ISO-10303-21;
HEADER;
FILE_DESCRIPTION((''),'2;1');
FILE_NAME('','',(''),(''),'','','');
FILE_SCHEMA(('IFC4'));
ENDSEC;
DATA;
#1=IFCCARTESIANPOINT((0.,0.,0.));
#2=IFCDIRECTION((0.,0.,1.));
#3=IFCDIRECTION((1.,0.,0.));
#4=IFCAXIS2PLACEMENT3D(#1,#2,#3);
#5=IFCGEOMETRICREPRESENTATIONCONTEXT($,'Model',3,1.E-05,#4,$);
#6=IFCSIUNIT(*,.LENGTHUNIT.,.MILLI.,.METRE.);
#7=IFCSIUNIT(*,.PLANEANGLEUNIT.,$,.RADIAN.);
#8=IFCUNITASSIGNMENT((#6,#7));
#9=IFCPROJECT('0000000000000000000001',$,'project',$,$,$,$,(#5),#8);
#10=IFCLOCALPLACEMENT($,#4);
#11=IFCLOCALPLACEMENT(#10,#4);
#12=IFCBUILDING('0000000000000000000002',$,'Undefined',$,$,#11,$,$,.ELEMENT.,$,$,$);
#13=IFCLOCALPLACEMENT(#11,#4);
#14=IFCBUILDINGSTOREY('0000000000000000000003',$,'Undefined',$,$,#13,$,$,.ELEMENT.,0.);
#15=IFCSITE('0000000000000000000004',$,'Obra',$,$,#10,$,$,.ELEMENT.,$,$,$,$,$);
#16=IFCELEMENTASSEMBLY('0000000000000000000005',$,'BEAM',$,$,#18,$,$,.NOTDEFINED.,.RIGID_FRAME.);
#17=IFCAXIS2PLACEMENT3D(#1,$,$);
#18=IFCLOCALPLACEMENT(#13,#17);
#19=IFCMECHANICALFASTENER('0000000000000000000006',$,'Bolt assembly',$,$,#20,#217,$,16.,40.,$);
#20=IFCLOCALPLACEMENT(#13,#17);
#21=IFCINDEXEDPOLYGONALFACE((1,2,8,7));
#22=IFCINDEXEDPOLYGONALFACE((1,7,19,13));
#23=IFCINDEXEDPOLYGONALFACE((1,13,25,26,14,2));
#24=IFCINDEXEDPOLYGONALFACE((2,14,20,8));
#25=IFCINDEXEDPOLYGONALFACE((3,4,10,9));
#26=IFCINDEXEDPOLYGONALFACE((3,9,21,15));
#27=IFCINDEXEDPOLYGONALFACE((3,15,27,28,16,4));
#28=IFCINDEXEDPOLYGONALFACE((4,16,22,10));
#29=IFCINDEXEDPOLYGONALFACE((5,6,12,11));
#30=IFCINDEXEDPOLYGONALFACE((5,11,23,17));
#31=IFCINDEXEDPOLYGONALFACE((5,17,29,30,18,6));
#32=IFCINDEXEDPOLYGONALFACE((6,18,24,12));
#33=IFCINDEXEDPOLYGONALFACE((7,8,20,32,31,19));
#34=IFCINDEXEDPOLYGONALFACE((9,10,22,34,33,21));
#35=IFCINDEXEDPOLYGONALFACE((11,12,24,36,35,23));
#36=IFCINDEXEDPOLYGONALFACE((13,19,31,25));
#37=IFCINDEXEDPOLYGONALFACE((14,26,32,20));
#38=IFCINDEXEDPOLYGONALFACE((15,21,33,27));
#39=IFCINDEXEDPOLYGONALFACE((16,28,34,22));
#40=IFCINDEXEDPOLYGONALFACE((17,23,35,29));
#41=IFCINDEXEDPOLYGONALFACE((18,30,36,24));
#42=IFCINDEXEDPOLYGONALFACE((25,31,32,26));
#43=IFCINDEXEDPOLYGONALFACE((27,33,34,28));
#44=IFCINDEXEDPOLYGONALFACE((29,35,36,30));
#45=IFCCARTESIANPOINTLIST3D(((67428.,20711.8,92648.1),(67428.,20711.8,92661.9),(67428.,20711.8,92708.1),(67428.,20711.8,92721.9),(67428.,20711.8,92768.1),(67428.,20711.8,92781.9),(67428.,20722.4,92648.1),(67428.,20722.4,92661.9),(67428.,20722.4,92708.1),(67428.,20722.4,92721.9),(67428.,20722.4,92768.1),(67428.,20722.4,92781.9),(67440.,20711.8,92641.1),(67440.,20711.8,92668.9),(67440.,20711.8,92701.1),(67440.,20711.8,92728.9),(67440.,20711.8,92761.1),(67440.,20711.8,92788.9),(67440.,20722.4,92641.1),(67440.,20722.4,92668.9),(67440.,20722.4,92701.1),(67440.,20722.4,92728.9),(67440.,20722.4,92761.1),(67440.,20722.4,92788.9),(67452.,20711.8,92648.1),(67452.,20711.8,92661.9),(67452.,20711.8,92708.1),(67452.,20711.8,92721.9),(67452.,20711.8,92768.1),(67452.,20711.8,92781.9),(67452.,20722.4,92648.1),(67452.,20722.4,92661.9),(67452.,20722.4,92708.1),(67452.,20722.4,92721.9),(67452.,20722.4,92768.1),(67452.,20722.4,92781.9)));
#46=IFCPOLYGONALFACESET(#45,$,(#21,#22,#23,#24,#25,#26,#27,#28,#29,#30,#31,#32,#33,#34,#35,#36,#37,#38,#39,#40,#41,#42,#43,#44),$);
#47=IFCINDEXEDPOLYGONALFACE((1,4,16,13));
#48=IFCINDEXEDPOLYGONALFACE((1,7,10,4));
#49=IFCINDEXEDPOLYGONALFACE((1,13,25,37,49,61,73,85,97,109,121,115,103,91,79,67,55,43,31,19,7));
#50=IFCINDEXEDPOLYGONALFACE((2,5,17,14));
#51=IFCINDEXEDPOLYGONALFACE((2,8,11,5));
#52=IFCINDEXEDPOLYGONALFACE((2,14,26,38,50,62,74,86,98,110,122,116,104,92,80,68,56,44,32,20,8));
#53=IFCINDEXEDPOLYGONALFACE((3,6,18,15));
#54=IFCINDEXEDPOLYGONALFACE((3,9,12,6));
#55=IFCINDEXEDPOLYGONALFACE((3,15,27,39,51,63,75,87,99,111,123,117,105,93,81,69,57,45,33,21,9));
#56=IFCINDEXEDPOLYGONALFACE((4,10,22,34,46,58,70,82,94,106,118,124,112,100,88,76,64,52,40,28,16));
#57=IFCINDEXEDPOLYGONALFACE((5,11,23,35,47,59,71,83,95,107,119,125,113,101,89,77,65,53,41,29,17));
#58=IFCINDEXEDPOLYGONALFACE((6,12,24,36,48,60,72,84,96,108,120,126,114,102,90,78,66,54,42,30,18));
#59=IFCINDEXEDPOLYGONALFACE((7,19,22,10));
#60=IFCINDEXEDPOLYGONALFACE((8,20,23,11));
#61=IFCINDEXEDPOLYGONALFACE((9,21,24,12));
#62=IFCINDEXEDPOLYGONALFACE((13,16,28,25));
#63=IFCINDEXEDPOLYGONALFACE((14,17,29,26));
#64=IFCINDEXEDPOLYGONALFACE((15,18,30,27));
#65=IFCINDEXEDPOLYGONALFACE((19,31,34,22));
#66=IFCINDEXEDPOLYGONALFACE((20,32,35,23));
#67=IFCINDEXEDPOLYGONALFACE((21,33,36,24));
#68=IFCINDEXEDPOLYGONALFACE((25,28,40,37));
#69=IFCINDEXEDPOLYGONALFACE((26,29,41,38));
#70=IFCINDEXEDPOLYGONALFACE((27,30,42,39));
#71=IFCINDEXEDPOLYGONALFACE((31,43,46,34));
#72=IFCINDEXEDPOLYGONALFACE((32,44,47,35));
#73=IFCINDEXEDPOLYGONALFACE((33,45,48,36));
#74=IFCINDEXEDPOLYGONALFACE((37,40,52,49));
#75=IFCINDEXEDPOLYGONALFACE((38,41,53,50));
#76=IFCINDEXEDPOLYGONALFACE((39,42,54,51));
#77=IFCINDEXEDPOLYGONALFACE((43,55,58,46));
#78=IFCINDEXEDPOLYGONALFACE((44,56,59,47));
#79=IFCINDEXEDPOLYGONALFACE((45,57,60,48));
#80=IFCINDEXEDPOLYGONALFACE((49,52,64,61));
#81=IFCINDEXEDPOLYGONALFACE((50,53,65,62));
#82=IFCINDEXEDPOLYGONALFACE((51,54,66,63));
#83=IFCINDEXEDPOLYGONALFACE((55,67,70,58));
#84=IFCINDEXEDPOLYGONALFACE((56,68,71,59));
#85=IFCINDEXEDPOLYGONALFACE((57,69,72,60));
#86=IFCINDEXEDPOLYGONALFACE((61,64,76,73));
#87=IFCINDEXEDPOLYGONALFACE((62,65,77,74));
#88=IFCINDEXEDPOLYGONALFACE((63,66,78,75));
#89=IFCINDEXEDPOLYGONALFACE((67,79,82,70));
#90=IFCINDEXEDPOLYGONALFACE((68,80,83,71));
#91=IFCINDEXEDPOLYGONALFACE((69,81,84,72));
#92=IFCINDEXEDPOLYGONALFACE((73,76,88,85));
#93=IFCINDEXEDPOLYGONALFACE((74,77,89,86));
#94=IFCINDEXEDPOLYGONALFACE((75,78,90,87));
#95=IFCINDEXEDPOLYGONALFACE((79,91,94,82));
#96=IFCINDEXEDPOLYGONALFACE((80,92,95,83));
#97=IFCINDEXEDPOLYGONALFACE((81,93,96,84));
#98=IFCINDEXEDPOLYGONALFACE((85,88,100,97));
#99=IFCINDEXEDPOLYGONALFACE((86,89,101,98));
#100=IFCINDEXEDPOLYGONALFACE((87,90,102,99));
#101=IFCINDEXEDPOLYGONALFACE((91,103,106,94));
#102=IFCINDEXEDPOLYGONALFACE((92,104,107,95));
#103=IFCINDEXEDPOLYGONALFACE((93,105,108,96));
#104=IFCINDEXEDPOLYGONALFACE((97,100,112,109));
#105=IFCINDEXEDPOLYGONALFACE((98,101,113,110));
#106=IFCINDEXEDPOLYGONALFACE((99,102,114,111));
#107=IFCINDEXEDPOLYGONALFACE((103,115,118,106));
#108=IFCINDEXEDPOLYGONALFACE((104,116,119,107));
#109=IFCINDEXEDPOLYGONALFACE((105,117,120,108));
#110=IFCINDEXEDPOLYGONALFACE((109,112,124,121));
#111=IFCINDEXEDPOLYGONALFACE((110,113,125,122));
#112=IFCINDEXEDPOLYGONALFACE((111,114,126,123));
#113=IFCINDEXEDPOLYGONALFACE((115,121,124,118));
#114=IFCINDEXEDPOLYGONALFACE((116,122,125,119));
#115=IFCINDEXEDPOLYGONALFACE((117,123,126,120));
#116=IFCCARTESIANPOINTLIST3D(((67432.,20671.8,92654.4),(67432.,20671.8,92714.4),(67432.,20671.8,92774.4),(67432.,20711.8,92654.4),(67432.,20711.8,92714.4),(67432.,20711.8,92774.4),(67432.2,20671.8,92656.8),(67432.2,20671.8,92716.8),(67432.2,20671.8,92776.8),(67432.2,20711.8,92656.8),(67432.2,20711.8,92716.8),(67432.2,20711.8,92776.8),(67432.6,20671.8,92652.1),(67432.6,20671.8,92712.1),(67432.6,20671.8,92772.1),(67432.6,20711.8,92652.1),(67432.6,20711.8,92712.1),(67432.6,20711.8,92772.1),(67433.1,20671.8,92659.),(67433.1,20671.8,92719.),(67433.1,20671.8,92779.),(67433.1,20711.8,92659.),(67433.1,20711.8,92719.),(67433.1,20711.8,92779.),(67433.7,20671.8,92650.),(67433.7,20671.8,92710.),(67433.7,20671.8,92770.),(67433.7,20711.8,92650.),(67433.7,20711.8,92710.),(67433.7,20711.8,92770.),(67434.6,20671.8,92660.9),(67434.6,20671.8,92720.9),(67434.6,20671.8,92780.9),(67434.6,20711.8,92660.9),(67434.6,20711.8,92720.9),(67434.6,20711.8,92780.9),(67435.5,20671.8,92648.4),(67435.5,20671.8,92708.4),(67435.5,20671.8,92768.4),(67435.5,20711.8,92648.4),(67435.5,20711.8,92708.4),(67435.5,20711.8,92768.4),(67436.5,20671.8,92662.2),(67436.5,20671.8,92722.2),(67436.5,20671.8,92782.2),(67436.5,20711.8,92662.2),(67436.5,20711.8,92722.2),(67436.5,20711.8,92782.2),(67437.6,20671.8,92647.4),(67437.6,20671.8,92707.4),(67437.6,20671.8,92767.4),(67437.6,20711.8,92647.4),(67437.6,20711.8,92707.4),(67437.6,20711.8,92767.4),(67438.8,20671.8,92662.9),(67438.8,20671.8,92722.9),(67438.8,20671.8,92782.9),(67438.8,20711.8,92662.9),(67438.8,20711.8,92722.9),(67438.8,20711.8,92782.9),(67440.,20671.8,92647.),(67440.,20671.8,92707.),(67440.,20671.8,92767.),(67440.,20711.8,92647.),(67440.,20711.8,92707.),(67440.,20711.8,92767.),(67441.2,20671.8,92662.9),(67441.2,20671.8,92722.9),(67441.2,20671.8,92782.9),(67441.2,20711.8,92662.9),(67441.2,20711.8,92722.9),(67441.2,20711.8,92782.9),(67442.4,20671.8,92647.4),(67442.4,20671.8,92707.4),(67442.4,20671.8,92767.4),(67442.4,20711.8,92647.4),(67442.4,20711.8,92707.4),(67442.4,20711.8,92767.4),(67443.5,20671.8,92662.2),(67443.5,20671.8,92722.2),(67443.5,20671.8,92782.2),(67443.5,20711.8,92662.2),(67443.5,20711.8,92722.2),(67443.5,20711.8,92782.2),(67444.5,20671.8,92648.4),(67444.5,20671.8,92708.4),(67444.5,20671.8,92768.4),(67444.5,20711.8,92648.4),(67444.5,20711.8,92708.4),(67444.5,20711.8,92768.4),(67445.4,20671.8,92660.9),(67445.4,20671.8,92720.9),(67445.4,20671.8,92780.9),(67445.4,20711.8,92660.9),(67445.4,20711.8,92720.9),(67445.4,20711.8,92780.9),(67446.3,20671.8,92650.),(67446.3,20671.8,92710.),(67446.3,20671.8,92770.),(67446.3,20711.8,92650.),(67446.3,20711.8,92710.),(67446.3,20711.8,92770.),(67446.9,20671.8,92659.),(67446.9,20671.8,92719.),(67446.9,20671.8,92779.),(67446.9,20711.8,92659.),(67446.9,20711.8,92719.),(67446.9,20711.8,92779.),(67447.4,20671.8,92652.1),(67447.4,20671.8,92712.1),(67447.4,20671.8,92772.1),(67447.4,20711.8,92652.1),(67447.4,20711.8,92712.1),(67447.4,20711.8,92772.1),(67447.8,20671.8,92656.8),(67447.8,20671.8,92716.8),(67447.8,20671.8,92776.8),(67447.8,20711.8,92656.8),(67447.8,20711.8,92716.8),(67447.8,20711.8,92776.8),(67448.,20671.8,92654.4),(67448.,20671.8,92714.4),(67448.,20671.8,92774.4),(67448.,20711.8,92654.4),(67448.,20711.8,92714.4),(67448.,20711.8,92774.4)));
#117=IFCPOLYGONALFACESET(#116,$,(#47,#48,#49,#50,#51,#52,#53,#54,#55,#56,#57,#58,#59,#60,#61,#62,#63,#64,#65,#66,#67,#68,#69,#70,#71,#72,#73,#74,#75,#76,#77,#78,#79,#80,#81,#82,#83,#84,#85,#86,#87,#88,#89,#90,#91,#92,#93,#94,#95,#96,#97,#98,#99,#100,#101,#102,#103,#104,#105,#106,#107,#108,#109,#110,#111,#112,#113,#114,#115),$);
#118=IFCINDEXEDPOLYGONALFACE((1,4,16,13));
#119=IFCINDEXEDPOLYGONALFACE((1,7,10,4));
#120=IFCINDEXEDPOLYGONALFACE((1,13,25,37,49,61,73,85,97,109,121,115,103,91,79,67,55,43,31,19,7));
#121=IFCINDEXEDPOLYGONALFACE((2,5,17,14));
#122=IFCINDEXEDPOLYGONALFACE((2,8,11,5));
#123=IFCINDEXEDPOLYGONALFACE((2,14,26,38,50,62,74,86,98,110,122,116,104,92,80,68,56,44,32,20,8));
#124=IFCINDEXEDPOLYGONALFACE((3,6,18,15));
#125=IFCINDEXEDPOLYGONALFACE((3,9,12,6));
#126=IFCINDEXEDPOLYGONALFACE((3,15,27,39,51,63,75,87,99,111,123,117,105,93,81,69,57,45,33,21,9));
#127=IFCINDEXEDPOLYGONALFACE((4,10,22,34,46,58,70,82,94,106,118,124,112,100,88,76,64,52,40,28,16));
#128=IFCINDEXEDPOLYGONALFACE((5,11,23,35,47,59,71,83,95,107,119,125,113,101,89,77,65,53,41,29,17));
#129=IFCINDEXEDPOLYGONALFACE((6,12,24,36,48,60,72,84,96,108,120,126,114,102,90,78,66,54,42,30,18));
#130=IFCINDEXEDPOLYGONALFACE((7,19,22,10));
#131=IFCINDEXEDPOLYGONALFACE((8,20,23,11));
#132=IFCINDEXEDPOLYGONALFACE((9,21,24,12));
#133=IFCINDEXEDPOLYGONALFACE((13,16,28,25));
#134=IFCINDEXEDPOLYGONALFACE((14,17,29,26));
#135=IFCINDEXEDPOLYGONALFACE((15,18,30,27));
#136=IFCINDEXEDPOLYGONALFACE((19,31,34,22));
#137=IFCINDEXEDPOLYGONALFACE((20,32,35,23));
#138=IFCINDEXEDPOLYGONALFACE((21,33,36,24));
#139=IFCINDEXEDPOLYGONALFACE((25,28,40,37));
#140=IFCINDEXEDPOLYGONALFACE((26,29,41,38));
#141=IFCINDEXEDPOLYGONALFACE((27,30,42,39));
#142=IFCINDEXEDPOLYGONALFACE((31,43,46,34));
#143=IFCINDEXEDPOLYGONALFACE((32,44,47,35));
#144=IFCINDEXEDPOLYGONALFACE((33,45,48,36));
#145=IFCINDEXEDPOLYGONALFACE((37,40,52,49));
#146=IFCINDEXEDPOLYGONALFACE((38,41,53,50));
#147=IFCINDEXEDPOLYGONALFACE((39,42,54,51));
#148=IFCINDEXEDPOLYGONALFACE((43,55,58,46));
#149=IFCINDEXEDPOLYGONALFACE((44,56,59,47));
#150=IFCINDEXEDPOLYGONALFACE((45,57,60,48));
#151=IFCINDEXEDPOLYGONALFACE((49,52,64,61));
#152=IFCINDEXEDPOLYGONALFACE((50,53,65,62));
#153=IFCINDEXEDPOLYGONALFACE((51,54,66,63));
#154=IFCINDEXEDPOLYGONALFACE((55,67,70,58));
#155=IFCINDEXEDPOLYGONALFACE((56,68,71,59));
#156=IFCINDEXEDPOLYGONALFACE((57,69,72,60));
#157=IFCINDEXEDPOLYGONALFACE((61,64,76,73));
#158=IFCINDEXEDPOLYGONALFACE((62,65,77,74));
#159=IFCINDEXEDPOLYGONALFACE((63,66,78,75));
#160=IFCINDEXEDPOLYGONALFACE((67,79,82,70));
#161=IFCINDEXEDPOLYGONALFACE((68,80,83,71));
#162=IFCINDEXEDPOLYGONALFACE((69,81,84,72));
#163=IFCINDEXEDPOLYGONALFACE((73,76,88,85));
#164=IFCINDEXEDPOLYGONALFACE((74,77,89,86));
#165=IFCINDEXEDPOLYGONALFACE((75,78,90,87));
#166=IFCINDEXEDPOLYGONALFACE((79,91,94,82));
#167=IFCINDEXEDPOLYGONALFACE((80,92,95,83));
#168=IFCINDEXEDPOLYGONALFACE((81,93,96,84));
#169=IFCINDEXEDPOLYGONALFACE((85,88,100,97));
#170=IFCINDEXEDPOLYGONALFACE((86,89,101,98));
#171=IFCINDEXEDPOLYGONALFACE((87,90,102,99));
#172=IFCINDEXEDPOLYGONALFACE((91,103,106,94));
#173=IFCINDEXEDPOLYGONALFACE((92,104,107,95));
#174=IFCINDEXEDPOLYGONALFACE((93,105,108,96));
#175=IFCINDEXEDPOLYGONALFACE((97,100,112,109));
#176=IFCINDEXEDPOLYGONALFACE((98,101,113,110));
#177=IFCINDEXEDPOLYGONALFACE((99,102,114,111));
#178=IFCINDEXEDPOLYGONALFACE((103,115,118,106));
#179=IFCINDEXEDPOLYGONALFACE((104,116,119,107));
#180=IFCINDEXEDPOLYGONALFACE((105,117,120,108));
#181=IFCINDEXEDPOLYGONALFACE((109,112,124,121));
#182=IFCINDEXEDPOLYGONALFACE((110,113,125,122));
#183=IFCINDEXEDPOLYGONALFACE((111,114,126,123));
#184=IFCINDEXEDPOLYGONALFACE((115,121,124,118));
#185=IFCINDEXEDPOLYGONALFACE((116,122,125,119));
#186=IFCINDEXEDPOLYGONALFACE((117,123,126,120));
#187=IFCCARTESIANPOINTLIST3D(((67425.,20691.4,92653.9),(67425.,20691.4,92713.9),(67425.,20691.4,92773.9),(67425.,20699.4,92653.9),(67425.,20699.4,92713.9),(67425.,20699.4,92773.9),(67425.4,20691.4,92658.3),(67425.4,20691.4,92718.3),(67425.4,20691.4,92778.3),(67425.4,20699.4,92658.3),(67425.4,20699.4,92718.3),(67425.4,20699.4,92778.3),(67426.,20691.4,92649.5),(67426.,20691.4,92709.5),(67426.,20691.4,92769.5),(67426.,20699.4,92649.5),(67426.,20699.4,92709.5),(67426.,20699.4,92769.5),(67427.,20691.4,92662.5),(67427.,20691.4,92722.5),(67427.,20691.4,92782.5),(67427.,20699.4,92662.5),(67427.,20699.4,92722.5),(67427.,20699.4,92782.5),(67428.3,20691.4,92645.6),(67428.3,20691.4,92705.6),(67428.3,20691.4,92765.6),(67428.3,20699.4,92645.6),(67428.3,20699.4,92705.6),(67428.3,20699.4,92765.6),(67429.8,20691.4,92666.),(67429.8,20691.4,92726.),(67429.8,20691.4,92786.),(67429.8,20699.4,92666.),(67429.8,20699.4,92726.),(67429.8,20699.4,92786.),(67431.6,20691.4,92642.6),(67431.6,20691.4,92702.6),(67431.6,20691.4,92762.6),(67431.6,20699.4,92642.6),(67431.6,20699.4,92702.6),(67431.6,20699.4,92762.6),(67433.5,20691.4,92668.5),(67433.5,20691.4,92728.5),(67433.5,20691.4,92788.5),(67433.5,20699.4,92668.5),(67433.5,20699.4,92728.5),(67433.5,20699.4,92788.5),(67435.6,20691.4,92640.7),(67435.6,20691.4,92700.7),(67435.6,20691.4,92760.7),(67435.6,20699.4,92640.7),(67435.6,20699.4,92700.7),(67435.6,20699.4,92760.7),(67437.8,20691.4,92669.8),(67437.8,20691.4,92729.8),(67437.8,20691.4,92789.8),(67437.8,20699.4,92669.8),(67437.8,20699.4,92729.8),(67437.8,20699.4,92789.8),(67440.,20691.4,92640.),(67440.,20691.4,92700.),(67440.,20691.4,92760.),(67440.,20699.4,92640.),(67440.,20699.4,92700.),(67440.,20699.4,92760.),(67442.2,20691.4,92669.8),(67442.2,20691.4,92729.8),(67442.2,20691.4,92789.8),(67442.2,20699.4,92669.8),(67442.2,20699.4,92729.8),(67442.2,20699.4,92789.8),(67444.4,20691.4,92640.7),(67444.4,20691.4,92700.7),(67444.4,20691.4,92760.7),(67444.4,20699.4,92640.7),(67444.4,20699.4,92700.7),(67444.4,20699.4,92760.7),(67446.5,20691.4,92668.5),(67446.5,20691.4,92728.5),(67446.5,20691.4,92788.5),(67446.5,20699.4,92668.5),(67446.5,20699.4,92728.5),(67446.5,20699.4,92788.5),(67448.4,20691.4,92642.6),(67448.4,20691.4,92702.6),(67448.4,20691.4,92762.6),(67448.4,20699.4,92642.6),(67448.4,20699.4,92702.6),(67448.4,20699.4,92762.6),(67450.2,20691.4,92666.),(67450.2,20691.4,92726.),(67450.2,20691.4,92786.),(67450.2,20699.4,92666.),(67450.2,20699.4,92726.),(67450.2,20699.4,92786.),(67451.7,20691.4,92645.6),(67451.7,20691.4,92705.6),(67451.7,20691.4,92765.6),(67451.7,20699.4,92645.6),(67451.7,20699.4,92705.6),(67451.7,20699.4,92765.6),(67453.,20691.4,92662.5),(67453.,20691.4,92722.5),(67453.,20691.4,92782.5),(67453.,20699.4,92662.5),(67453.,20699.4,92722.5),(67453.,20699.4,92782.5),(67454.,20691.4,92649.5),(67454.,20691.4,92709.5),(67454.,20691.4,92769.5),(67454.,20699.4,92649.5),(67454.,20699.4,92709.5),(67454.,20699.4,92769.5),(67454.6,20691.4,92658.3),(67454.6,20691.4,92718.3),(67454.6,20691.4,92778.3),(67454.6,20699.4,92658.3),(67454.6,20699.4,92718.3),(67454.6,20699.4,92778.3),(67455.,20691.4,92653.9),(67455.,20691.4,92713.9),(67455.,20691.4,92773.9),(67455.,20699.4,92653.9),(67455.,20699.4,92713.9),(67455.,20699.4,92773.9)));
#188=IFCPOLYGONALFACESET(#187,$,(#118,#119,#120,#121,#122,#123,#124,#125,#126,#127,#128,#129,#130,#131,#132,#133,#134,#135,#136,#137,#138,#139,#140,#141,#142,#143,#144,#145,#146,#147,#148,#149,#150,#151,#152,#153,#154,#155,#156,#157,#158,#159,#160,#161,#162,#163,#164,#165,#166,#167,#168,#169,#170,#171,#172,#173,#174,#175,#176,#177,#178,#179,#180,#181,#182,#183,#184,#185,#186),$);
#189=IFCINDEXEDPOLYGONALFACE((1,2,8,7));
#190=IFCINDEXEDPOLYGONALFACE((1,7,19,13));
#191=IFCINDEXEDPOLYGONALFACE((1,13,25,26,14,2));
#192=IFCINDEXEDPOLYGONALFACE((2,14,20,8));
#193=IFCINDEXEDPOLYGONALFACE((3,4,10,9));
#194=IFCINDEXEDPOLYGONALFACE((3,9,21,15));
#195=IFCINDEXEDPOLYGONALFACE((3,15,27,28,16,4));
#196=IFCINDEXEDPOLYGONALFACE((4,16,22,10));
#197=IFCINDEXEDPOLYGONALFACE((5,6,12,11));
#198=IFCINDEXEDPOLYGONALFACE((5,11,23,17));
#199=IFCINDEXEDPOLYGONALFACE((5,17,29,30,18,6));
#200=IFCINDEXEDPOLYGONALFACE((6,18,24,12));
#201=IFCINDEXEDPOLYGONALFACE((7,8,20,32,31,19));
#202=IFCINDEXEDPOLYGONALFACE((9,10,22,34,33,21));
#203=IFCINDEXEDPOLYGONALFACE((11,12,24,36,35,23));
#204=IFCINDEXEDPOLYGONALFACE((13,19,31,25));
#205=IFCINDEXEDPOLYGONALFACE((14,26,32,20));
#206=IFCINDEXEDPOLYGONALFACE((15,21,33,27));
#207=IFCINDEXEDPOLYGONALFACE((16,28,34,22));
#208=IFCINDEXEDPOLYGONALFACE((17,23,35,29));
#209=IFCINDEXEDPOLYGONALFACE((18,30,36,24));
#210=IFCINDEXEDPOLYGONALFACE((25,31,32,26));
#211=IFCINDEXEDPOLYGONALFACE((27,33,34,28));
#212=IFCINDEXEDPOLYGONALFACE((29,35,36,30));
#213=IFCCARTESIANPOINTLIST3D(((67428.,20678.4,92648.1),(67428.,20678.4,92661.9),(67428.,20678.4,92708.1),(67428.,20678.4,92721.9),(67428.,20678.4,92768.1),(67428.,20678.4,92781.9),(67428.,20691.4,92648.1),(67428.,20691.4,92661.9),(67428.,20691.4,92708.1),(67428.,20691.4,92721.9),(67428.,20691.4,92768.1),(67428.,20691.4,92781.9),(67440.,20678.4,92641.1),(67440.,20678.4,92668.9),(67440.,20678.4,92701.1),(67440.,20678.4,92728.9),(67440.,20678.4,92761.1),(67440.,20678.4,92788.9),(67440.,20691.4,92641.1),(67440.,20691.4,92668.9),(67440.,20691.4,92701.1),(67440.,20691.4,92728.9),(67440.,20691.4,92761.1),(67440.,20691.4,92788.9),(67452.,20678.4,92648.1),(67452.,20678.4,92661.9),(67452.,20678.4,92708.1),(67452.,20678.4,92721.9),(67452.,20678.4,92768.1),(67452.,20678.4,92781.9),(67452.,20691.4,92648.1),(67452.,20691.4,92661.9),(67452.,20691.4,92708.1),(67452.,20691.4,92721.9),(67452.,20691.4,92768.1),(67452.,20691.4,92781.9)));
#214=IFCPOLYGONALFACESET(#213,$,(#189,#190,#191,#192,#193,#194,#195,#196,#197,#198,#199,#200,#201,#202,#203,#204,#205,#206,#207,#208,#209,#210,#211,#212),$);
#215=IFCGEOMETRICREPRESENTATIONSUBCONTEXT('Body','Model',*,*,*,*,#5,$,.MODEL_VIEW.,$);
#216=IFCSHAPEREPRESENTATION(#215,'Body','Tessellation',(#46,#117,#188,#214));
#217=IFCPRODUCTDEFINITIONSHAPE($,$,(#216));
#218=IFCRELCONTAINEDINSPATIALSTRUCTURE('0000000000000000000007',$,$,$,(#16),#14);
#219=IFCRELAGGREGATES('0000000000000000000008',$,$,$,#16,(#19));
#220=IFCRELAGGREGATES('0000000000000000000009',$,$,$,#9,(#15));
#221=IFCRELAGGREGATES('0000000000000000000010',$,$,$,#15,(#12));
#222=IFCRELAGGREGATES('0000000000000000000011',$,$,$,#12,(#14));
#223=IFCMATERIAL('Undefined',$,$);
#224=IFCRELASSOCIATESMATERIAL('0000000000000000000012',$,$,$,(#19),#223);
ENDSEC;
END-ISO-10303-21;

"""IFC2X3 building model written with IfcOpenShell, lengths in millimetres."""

from ifc_helpers import new_model, si_unit, frame, origin_with_axes, origin_2d_with_axis, place, context, subcontext, project, spatial, polyline, circle, outline, extrude, source, transform, mapped, material, element, aggregate, save


model = new_model("IFC2X3")

# Units and contexts
model_context = context("Model", 3, precision=1e-05, world=origin_with_axes())
body_context = subcontext(model_context, "Body", "Model", "MODEL_VIEW")
ifc_project = project(units=[si_unit("LENGTHUNIT", "METRE", prefix="MILLI"), si_unit("PLANEANGLEUNIT", "RADIAN")], contexts=[model_context])

# Site, building, storey
site_placement = place(None, origin_with_axes())
site = spatial("IfcSite", under=ifc_project, at=site_placement, Name="Obra", CompositionType="ELEMENT")
building_placement = place(site_placement, origin_with_axes())
building = spatial("IfcBuilding", under=site, at=building_placement, Name="Undefined", CompositionType="ELEMENT")
storey_placement = place(building_placement, origin_with_axes())
storey = spatial("IfcBuildingStorey", under=building, at=storey_placement, Name="Undefined", CompositionType="ELEMENT", Elevation=0.0)

# Shared definitions
ifc_material_1 = material(Name="Undefined")

# Element assembly, mechanical fastener
assembly_1_placement = place(storey_placement, origin_with_axes())
assembly_1 = element("IfcElementAssembly", 1, at=assembly_1_placement, inside=storey, Name="BEAM", AssemblyPlace="NOTDEFINED", PredefinedType="RIGID_FRAME")
shared_shape_1 = source(origin_with_axes(), body_context, "Body", "SweptSolid", [
    extrude(outline(polyline([(13.9, 0.0), (6.9, 12.0), (-6.9, 12.0), (-13.9, 0.0), (-6.9, -12.0), (6.9, -12.0), (13.9, 0.0)])), frame((0.0, -19.7, 0.0), z_axis=(0.0, 1.0, 0.0), x_axis=(1.0, 0.0, 0.0)), (0.0, 0.0, 1.0), 10.6),
    extrude(circle(Radius=8.0, at=origin_2d_with_axis()), frame((0.0, -9.1, 0.0), z_axis=(0.0, 1.0, 0.0), x_axis=(1.0, 0.0, 0.0)), (0.0, 0.0, 1.0), 40.0),
    extrude(circle(Radius=15.0, at=origin_2d_with_axis()), frame((0.0, 3.3, 0.0), z_axis=(0.0, 1.0, 0.0), x_axis=(1.0, 0.0, 0.0)), (0.0, 0.0, 1.0), 8.0),
    extrude(outline(polyline([(13.9, 0.0), (6.9, 12.0), (-6.9, 12.0), (-13.9, 0.0), (-6.9, -12.0), (6.9, -12.0), (13.9, 0.0)])), frame((0.0, 11.3, 0.0), z_axis=(0.0, 1.0, 0.0), x_axis=(1.0, 0.0, 0.0)), (0.0, 0.0, 1.0), 13.0),
])
mechanical_fastener_1_placement = place(assembly_1_placement, frame((67490.0, 20702.7, 92835.0), z_axis=(-1.0, 0.0, 0.0), x_axis=(0.0, 0.0, -1.0)))
mechanical_fastener_1 = element("IfcMechanicalFastener", 2, at=mechanical_fastener_1_placement, material=ifc_material_1, Name="Bolt assembly", NominalDiameter=16.0, NominalLength=40.0, context=body_context, shape_type="MappedRepresentation", body=[
    mapped(shared_shape_1, transform((60.0, 0.0, 50.0))),
    mapped(shared_shape_1, transform((120.0, 0.0, 50.0))),
    mapped(shared_shape_1, transform((180.0, 0.0, 50.0))),
])
aggregate(assembly_1, [mechanical_fastener_1])

save(model, "model.ifc")
